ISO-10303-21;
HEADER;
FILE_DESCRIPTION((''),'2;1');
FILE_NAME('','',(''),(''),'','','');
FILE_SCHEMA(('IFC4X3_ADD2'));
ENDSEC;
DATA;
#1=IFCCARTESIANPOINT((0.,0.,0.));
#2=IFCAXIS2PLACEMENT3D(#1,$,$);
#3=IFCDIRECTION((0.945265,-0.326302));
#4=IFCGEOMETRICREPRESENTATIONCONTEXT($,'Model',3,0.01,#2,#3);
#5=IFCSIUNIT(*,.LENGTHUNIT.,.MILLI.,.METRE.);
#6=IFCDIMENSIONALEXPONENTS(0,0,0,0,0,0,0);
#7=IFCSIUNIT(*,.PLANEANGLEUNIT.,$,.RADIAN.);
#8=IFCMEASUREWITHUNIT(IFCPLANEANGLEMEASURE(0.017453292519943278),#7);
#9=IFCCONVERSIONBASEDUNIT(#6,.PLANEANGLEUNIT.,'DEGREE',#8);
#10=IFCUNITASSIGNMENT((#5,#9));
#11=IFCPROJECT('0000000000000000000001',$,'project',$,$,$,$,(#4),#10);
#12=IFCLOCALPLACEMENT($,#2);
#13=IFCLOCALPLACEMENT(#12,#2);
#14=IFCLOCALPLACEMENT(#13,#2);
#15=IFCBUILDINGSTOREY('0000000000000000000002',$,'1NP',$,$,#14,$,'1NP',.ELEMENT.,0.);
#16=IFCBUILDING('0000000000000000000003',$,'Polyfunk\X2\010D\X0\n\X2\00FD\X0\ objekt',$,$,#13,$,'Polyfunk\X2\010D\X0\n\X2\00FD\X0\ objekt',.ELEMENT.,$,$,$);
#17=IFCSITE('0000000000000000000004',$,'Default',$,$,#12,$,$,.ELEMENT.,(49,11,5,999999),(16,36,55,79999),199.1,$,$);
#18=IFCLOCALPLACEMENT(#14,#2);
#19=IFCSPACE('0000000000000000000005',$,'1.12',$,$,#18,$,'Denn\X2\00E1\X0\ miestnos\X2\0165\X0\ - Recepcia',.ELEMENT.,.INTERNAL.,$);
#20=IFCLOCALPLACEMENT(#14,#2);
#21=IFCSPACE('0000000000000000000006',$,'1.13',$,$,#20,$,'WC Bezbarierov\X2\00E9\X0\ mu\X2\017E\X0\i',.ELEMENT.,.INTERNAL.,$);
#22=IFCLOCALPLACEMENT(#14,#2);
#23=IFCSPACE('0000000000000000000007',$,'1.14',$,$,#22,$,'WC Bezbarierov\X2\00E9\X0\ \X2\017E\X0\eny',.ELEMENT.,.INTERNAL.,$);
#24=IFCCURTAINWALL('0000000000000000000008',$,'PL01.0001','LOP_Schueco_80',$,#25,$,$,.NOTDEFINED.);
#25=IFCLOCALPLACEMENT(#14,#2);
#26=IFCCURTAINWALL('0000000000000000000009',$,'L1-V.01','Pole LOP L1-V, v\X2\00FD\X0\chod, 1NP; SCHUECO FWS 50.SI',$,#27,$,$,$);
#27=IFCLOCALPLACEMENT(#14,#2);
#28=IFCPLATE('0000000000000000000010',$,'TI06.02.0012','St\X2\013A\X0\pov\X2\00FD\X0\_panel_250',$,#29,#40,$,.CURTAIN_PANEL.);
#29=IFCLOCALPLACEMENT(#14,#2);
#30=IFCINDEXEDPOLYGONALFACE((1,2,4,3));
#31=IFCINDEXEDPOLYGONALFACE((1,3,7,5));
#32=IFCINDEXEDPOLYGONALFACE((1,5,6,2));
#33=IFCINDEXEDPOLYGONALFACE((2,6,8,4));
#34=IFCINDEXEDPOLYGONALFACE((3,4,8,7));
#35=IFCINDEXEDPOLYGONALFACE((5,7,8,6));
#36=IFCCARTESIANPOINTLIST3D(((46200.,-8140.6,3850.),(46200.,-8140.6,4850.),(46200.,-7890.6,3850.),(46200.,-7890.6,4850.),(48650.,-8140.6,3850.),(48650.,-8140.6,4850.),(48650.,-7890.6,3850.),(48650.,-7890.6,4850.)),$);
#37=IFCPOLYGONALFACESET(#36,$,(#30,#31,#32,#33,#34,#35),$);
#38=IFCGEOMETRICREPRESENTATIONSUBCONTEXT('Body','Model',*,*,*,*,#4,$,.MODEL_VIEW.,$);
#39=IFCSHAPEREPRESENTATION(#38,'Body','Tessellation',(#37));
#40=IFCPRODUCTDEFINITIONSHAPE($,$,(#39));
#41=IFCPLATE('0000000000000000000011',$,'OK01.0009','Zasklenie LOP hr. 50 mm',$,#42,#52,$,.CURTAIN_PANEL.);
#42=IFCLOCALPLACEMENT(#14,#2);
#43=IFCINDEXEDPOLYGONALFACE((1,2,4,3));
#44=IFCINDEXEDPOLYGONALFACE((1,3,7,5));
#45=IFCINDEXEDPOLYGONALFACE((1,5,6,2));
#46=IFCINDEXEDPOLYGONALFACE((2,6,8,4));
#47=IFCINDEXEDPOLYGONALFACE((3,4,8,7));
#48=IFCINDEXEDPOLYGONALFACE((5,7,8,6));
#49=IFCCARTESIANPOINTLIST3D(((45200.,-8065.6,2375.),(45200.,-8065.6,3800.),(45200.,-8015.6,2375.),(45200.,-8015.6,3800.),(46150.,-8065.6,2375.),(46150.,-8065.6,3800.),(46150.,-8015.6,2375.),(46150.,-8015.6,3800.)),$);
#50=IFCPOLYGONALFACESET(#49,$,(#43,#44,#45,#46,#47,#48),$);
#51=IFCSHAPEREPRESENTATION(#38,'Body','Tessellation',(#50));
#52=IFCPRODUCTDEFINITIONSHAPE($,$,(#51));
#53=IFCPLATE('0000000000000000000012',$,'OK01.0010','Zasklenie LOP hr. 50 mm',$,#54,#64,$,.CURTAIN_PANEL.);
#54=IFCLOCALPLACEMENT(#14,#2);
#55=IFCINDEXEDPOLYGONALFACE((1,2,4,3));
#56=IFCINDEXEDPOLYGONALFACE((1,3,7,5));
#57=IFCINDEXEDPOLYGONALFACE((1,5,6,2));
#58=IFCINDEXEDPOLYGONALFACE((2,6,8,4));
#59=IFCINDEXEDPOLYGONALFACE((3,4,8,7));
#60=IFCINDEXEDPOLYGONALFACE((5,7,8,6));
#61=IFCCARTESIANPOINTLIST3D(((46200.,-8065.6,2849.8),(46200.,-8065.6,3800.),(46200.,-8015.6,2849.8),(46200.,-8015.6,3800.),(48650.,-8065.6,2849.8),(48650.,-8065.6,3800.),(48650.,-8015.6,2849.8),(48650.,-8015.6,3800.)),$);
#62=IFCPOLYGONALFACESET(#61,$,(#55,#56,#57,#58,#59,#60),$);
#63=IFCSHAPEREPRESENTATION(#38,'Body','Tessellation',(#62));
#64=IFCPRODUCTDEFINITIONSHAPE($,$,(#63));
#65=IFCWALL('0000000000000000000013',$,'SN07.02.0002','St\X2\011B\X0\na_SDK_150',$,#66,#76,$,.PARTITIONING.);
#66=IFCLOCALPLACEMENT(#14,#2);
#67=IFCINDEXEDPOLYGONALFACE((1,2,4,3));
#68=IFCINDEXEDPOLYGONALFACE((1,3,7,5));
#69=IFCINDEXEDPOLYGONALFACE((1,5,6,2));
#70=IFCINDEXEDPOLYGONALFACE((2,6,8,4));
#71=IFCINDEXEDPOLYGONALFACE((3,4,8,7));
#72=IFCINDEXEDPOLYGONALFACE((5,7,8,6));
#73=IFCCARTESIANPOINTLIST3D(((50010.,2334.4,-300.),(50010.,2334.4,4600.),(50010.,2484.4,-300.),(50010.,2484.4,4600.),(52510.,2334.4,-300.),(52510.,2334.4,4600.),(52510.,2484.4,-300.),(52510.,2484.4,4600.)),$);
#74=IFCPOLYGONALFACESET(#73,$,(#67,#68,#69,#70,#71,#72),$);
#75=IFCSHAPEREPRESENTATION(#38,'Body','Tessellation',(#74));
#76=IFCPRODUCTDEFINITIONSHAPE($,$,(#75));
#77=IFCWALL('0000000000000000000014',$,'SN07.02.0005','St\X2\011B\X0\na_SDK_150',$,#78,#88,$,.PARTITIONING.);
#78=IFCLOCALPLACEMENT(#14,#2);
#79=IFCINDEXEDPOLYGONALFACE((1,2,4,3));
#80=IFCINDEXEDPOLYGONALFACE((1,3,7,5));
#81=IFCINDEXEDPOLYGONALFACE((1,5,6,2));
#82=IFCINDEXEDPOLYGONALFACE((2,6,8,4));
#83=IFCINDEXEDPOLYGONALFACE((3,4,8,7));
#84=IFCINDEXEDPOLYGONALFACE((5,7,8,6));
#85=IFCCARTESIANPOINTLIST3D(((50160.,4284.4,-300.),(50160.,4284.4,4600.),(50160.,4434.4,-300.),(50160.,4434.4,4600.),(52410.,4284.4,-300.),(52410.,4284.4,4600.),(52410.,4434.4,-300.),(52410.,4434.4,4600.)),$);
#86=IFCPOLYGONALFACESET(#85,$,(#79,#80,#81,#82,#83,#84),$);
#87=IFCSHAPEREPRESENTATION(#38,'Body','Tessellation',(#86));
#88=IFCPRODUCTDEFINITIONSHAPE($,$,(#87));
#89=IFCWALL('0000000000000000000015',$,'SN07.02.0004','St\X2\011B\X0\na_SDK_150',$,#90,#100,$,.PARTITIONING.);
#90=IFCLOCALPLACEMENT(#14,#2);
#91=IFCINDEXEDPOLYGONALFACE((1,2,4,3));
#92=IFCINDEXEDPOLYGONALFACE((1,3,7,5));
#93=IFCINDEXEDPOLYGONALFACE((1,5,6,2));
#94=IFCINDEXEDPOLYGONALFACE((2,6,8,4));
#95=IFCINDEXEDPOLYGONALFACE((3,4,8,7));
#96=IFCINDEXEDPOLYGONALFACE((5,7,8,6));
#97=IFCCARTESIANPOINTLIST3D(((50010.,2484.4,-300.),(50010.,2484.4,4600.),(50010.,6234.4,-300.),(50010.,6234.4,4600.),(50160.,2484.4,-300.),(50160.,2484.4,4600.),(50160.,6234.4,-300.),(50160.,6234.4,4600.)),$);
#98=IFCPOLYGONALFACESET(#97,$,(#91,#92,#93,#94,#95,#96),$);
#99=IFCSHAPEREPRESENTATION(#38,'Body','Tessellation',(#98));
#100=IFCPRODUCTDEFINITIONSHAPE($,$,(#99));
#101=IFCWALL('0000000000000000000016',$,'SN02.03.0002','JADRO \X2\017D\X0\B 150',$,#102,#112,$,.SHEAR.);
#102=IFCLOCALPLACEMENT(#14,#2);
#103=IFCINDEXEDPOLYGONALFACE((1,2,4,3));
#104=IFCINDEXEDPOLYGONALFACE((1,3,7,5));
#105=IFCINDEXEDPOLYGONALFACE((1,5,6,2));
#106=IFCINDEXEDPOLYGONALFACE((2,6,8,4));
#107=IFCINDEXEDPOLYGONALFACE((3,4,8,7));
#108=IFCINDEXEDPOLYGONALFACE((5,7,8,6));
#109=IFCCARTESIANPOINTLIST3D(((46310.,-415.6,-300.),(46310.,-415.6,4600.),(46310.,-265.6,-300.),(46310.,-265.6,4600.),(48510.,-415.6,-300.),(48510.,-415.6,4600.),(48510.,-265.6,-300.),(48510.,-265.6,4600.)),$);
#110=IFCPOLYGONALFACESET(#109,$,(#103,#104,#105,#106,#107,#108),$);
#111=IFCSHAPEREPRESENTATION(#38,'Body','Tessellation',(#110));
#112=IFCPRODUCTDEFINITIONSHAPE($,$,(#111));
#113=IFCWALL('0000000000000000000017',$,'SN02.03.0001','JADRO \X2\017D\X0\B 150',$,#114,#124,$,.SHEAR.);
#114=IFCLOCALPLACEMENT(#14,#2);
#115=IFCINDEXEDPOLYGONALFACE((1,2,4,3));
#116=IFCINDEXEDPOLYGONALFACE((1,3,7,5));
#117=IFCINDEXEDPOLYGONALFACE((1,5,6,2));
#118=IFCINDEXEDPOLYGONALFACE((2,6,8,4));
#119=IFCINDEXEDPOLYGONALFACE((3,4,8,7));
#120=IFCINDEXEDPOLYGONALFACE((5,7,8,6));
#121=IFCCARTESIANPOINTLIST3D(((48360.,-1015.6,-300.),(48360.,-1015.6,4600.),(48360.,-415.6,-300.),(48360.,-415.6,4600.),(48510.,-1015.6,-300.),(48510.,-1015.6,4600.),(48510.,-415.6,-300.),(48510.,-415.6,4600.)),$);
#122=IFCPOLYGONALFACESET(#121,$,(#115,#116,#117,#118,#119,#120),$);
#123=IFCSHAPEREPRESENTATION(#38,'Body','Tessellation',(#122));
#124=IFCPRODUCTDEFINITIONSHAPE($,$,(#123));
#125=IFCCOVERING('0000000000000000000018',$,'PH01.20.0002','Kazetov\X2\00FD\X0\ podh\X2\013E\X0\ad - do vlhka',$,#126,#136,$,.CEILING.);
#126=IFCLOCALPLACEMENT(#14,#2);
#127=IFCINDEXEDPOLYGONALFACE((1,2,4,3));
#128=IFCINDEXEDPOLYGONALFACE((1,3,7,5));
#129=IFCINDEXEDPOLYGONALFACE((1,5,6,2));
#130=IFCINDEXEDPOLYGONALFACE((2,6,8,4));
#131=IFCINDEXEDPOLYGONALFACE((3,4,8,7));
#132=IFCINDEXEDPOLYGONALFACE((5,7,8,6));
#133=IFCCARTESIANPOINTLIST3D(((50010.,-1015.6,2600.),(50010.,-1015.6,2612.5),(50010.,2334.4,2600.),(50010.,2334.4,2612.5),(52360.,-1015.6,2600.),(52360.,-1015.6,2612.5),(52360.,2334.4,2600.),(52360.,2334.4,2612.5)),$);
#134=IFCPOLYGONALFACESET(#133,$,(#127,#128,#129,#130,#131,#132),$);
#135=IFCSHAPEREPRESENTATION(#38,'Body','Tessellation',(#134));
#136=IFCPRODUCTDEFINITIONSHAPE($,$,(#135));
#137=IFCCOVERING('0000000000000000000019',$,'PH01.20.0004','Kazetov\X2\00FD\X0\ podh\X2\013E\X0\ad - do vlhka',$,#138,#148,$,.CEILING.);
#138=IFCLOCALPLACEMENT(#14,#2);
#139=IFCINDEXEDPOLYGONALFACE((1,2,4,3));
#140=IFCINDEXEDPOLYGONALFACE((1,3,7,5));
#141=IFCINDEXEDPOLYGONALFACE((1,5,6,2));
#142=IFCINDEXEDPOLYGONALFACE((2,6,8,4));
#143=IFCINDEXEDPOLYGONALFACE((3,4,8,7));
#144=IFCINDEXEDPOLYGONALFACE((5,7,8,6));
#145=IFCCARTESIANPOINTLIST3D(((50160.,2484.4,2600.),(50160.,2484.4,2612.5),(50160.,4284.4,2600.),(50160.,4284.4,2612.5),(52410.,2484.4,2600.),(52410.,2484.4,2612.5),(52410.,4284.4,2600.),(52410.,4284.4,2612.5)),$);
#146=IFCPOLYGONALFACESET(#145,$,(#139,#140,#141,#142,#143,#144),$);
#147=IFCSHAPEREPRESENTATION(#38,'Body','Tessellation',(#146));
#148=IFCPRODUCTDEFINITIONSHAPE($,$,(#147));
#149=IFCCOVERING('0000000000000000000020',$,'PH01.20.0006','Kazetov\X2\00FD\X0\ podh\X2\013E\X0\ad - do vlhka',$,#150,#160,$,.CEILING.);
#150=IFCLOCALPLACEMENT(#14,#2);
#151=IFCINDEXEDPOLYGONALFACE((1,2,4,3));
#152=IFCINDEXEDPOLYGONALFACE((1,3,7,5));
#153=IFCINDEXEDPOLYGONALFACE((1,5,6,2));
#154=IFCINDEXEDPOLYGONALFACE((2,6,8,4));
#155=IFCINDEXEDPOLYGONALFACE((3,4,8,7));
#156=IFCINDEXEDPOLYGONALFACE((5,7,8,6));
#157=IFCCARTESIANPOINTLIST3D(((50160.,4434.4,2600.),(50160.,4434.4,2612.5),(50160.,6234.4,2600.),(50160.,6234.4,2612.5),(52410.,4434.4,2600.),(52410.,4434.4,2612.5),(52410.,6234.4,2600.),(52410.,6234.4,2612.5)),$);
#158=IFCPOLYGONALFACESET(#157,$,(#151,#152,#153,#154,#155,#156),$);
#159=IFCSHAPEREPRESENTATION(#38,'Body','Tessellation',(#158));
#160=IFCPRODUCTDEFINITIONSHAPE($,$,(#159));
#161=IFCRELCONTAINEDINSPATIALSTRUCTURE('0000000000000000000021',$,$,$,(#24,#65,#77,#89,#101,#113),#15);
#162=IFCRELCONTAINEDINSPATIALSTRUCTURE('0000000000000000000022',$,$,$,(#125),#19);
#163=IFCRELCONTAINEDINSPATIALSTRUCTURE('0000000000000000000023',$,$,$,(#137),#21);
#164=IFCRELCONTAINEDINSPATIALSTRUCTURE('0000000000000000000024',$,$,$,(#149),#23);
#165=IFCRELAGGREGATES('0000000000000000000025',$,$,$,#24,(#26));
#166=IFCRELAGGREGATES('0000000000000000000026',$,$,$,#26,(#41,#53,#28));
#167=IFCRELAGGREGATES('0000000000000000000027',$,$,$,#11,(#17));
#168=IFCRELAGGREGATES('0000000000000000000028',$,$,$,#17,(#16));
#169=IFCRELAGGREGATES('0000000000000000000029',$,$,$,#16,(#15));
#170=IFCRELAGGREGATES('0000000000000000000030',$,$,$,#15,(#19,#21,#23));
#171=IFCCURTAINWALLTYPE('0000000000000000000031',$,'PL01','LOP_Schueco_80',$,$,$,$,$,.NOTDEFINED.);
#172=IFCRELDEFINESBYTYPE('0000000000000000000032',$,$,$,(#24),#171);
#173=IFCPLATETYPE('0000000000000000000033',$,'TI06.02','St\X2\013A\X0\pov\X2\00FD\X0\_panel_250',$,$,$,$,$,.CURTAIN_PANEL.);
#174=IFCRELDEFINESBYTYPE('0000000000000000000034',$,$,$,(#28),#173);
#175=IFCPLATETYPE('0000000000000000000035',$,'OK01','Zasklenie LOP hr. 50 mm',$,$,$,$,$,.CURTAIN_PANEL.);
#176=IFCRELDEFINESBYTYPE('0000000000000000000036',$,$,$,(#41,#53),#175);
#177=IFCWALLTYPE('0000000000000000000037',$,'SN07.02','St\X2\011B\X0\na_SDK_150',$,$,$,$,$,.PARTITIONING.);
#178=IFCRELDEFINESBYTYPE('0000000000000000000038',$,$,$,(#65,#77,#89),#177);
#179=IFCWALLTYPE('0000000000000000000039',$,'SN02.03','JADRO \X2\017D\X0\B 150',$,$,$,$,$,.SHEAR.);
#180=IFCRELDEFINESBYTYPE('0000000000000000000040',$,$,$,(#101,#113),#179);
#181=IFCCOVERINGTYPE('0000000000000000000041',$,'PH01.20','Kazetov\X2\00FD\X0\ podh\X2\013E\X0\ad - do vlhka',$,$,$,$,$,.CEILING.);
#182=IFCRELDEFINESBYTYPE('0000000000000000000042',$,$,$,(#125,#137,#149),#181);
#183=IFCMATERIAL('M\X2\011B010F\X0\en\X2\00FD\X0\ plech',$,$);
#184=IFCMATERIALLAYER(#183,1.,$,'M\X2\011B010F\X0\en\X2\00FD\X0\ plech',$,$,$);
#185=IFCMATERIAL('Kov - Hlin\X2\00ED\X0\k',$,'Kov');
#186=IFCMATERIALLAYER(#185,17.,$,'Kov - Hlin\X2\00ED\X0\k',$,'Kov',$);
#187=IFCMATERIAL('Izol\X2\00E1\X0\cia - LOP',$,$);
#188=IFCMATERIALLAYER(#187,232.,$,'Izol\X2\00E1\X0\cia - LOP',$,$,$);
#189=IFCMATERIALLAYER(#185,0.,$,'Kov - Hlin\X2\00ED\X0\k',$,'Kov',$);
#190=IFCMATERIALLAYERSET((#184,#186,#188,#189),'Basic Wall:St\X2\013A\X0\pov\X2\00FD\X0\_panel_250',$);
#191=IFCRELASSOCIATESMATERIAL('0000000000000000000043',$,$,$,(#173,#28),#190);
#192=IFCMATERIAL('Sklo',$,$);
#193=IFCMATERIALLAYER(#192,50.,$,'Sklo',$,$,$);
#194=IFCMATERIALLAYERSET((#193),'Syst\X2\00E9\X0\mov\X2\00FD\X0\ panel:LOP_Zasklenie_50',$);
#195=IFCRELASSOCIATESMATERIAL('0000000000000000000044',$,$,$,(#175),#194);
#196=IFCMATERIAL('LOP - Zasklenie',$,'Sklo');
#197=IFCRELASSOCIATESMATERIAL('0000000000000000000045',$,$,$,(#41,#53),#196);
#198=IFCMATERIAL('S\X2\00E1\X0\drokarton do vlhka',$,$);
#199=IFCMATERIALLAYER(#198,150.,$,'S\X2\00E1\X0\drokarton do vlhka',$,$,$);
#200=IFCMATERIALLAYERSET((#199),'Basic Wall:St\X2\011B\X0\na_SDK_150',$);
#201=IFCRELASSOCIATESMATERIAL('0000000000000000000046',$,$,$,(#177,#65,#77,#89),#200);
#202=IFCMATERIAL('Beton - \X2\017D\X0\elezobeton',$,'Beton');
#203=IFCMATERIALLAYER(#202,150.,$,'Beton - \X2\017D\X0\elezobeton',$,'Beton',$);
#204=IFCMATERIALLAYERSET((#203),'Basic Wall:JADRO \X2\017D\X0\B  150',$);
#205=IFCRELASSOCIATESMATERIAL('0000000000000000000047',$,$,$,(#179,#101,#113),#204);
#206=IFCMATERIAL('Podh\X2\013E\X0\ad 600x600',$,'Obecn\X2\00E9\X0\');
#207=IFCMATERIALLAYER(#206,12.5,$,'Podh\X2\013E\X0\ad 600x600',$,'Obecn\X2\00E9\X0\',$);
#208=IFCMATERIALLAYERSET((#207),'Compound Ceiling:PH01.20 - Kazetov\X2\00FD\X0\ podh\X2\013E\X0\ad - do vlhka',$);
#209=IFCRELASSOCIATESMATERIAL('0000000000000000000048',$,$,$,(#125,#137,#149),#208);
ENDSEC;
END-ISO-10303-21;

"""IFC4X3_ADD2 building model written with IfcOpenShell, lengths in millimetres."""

from ifc_helpers import new_model, entity, si_unit, converted_unit, direction, frame, frame_2d, origin, origin_2d_with_axis, place, context, subcontext, project, spatial, polyline, rectangle, extrude, clip, bounded_halfspace, source, transform, mapped, material, layer, layer_set, layer_usage, type_object, type_shapes, element, aggregate, save


model = new_model("IFC4X3_ADD2")

# Units and contexts
model_context = context("Model", 3, precision=0.01, world=origin(), true_north=direction((0.945265, -0.326302)))
body_context = subcontext(model_context, "Body", "Model", "MODEL_VIEW")
ifc_project = project(units=[si_unit("LENGTHUNIT", "METRE", prefix="MILLI"), converted_unit("PLANEANGLEUNIT", "DEGREE", entity("IfcPlaneAngleMeasure", 0.017453292519943278), si_unit("PLANEANGLEUNIT", "RADIAN"), dimensions=[0, 0, 0, 0, 0, 0, 0])], contexts=[model_context])

# Site, building, storey
site_placement = place(None, origin())
site = spatial("IfcSite", under=ifc_project, at=site_placement, Name="Default", CompositionType="ELEMENT", RefLatitude=(49, 11, 5, 999999), RefLongitude=(16, 36, 55, 79999), RefElevation=199.1)
building_placement = place(site_placement, origin())
building = spatial("IfcBuilding", under=site, at=building_placement, Name="Polyfunkčný objekt", LongName="Polyfunkčný objekt", CompositionType="ELEMENT")
storey_placement = place(building_placement, origin())
storey = spatial("IfcBuildingStorey", under=building, at=storey_placement, Name="1NP", LongName="1NP", CompositionType="ELEMENT", Elevation=0.0)

# Curtain walls, plates
curtain_wall_type = type_object("IfcCurtainWallType", Name="PL01", Description="LOP_Schueco_80", PredefinedType="NOTDEFINED")
curtain_wall_1_placement = place(storey_placement, origin())
curtain_wall_1 = element("IfcCurtainWall", 1, at=curtain_wall_1_placement, inside=storey, type_object=curtain_wall_type, Name="PL01.0001", Description="LOP_Schueco_80", PredefinedType="NOTDEFINED")
curtain_wall_2 = element("IfcCurtainWall", 2, Name="L1-V.01", Description="Pole LOP L1-V, východ, 1NP; SCHUECO FWS 50.SI")
aggregate(curtain_wall_1, [curtain_wall_2])
ifc_material_1 = material(Name="Měďený plech")
ifc_layer_1 = layer(ifc_material_1, 1.0, Name="Měďený plech")
ifc_material_2 = material(Name="Kov - Hliník", Category="Kov")
ifc_layer_2 = layer(ifc_material_2, 17.0, Name="Kov - Hliník", Category="Kov")
ifc_material_3 = material(Name="Izolácia - LOP")
ifc_layer_3 = layer(ifc_material_3, 232.0, Name="Izolácia - LOP")
ifc_layer_4 = layer(ifc_material_2, 0.0, Name="Kov - Hliník", Category="Kov")
ifc_layer_set_1 = layer_set([ifc_layer_1, ifc_layer_2, ifc_layer_3, ifc_layer_4], Name="Basic Wall:Stĺpový_panel_250")
ifc_layer_usage_1 = layer_usage(ifc_layer_set_1, "AXIS2", "POSITIVE", -125.0)
plate_type_1 = type_object("IfcPlateType", Name="TI06.02", Description="Stĺpový_panel_250", PredefinedType="CURTAIN_PANEL", material=ifc_layer_set_1)
plate_1_placement = place(storey_placement, frame((46200.0, -8015.6, 3850.0)))
plate_1 = element("IfcPlate", 3, at=plate_1_placement, type_object=plate_type_1, material=ifc_layer_usage_1, Name="TI06.02.0012", Description="Stĺpový_panel_250", PredefinedType="CURTAIN_PANEL", context=body_context, shape_type="SweptSolid", body=[
    extrude(rectangle(XDim=250.0, YDim=2450.0, at=origin_2d_with_axis()), frame((1225.0, 0.0, 0.0), z_axis=(0.0, 0.0, 1.0), x_axis=(0.0, 1.0, 0.0)), (0.0, 0.0, 1.0), 1000.0),
])
ifc_material_4 = material(Name="LOP - Zasklenie", Category="Sklo")
ifc_material_5 = material(Name="Sklo")
ifc_layer_5 = layer(ifc_material_5, 50.0, Name="Sklo")
ifc_layer_set_2 = layer_set([ifc_layer_5], Name="Systémový panel:LOP_Zasklenie_50")
plate_type_2 = type_object("IfcPlateType", Name="OK01", Description="Zasklenie LOP hr. 50 mm", PredefinedType="CURTAIN_PANEL", material=ifc_layer_set_2)
shared_shape_1 = source(origin(), body_context, "Body", "SweptSolid", [
    extrude(rectangle(XDim=1425.0, YDim=950.0, at=frame_2d((87.6, 0.0), x_axis=(1.0, 0.0))), frame((0.0, -50.0, 624.9), z_axis=(0.0, 1.0, 0.0), x_axis=(0.0, 0.0, 1.0)), (0.0, 0.0, 1.0), 50.0),
])
plate_2_placement = place(curtain_wall_1_placement, frame((45675.0, -8015.6, 2375.0)))
plate_2 = element("IfcPlate", 4, at=plate_2_placement, type_object=plate_type_2, material=ifc_material_4, Name="OK01.0009", Description="Zasklenie LOP hr. 50 mm", PredefinedType="CURTAIN_PANEL", context=body_context, shape_type="MappedRepresentation", body=[
    mapped(shared_shape_1, transform((0.0, 0.0, 0.0), scale=1.0)),
])
shared_shape_2 = source(origin(), body_context, "Body", "SweptSolid", [
    extrude(rectangle(XDim=50.0, YDim=2450.0, at=origin_2d_with_axis()), frame((0.0, -25.0, 0.0), z_axis=(0.0, 0.0, 1.0), x_axis=(0.0, 1.0, 0.0)), (0.0, 0.0, 1.0), 950.2),
])
type_shapes(plate_type_2, [shared_shape_1, shared_shape_2])
plate_3_placement = place(curtain_wall_1_placement, frame((47425.0, -8015.6, 2849.8)))
plate_3 = element("IfcPlate", 5, at=plate_3_placement, type_object=plate_type_2, material=ifc_material_4, Name="OK01.0010", Description="Zasklenie LOP hr. 50 mm", PredefinedType="CURTAIN_PANEL", context=body_context, shape_type="MappedRepresentation", body=[
    mapped(shared_shape_2, transform((0.0, 0.0, 0.0), scale=1.0)),
])
aggregate(curtain_wall_2, [plate_2, plate_3, plate_1])

# Walls
ifc_material_6 = material(Name="Sádrokarton do vlhka")
ifc_layer_6 = layer(ifc_material_6, 150.0, Name="Sádrokarton do vlhka")
ifc_layer_set_3 = layer_set([ifc_layer_6], Name="Basic Wall:Stěna_SDK_150")
wall_type_1 = type_object("IfcWallType", Name="SN07.02", Description="Stěna_SDK_150", PredefinedType="PARTITIONING", material=ifc_layer_set_3)
wall_1_placement = place(storey_placement, frame((50010.0, 2409.4, -300.0)))
element("IfcWall", 6, at=wall_1_placement, inside=storey, type_object=wall_type_1, material=ifc_layer_set_3, Name="SN07.02.0002", Description="Stěna_SDK_150", PredefinedType="PARTITIONING", context=body_context, shape_type="Clipping", body=[
    clip(clip(extrude(rectangle(XDim=2500.0, YDim=150.0, at=frame_2d((1250.0, 0.0), x_axis=(-1.0, 0.0))), origin(), (0.0, 0.0, 1.0), 4900.0), bounded_halfspace(frame((2500.0, -75.0, 0.0), z_axis=(0.0, 0.0, 1.0), x_axis=(0.0, 1.0, 0.0)), True, frame((2500.0, -75.0, 0.0)), polyline([(0.0, 0.0), (0.0, 150.0), (-100.0, 150.0), (-2350.0, 150.0), (-2500.0, 150.0), (-2500.0, 0.0), (-150.0, 0.0), (0.0, 0.0)]))), bounded_halfspace(frame((0.0, -75.0, 4900.0), z_axis=(0.0, 0.0, -1.0), x_axis=(1.0, 0.0, 0.0)), True, frame((0.0, -75.0, 4900.0)), polyline([(0.0, 0.0), (2350.0, 0.0), (2500.0, 0.0), (2500.0, 150.0), (2400.0, 150.0), (150.0, 150.0), (0.0, 150.0), (0.0, 0.0)]))),
])
wall_2_placement = place(storey_placement, frame((50160.0, 4359.4, -300.0)))
element("IfcWall", 7, at=wall_2_placement, inside=storey, type_object=wall_type_1, material=ifc_layer_set_3, Name="SN07.02.0005", Description="Stěna_SDK_150", PredefinedType="PARTITIONING", context=body_context, shape_type="Clipping", body=[
    clip(clip(extrude(rectangle(XDim=2250.0, YDim=150.0, at=frame_2d((1125.0, 0.0), x_axis=(-1.0, 0.0))), origin(), (0.0, 0.0, 1.0), 4900.0), bounded_halfspace(frame((2250.0, -75.0, 0.0), z_axis=(0.0, 0.0, 1.0), x_axis=(0.0, 1.0, 0.0)), True, frame((2250.0, -75.0, 0.0)), polyline([(0.0, 0.0), (0.0, 150.0), (-2250.0, 150.0), (-2250.0, 0.0), (0.0, 0.0)]))), bounded_halfspace(frame((0.0, -75.0, 4900.0), z_axis=(0.0, 0.0, -1.0), x_axis=(1.0, 0.0, 0.0)), True, frame((0.0, -75.0, 4900.0)), polyline([(0.0, 0.0), (2250.0, 0.0), (2250.0, 150.0), (0.0, 150.0), (0.0, 0.0)]))),
])
wall_3_placement = place(storey_placement, frame((50085.0, 2484.4, -300.0), z_axis=(0.0, 0.0, 1.0), x_axis=(0.0, 1.0, 0.0)))
element("IfcWall", 8, at=wall_3_placement, inside=storey, type_object=wall_type_1, material=ifc_layer_set_3, Name="SN07.02.0004", Description="Stěna_SDK_150", PredefinedType="PARTITIONING", context=body_context, shape_type="Clipping", body=[
    clip(clip(extrude(rectangle(XDim=3750.0, YDim=150.0, at=frame_2d((1875.0, 0.0), x_axis=(-1.0, 0.0))), origin(), (0.0, 0.0, 1.0), 4900.0), bounded_halfspace(frame((0.0, -75.0, 4900.0), z_axis=(0.0, 0.0, -1.0), x_axis=(0.0, -1.0, 0.0)), True, frame((0.0, -75.0, 4900.0)), polyline([(0.0, 0.0), (1800.0, 0.0), (1950.0, 0.0), (3750.0, 0.0), (3750.0, 150.0), (0.0, 150.0), (0.0, 0.0)]))), bounded_halfspace(frame((3750.0, -75.0, 0.0)), True, frame((3750.0, -75.0, 0.0)), polyline([(0.0, 0.0), (0.0, 150.0), (-3750.0, 150.0), (-3750.0, 0.0), (-1950.0, 0.0), (-1800.0, 0.0), (0.0, 0.0)]))),
])
ifc_material_7 = material(Name="Beton - Železobeton", Category="Beton")
ifc_layer_7 = layer(ifc_material_7, 150.0, Name="Beton - Železobeton", Category="Beton")
ifc_layer_set_4 = layer_set([ifc_layer_7], Name="Basic Wall:JADRO ŽB  150")
wall_type_2 = type_object("IfcWallType", Name="SN02.03", Description="JADRO ŽB 150", PredefinedType="SHEAR", material=ifc_layer_set_4)
wall_4_placement = place(storey_placement, frame((46310.0, -340.6, -300.0)))
element("IfcWall", 9, at=wall_4_placement, inside=storey, type_object=wall_type_2, material=ifc_layer_set_4, Name="SN02.03.0002", Description="JADRO ŽB 150", PredefinedType="SHEAR", context=body_context, shape_type="SweptSolid", body=[
    extrude(rectangle(XDim=2200.0, YDim=150.0, at=frame_2d((1100.0, 0.0), x_axis=(-1.0, 0.0))), origin(), (0.0, 0.0, 1.0), 4900.0),
])
wall_5_placement = place(storey_placement, frame((48435.0, -1015.6, -300.0), z_axis=(0.0, 0.0, 1.0), x_axis=(0.0, 1.0, 0.0)))
element("IfcWall", 10, at=wall_5_placement, inside=storey, type_object=wall_type_2, material=ifc_layer_set_4, Name="SN02.03.0001", Description="JADRO ŽB 150", PredefinedType="SHEAR", context=body_context, shape_type="SweptSolid", body=[
    extrude(rectangle(XDim=600.0, YDim=150.0, at=frame_2d((300.0, 0.0), x_axis=(-1.0, 0.0))), origin(), (0.0, 0.0, 1.0), 4900.0),
])

# Shared definitions
space_1_placement = place(storey_placement, origin())
space_1 = spatial("IfcSpace", under=storey, at=space_1_placement, Name="1.12", LongName="Denná miestnosť - Recepcia", CompositionType="ELEMENT", PredefinedType="INTERNAL")

# Covering
ifc_material_8 = material(Name="Podhľad 600x600", Category="Obecné")
ifc_layer_8 = layer(ifc_material_8, 12.5, Name="Podhľad 600x600", Category="Obecné")
ifc_layer_set_5 = layer_set([ifc_layer_8], Name="Compound Ceiling:PH01.20 - Kazetový podhľad - do vlhka")
ifc_layer_usage_2 = layer_usage(ifc_layer_set_5, "AXIS3", "NEGATIVE", 12.5)
covering_type = type_object("IfcCoveringType", Name="PH01.20", Description="Kazetový podhľad - do vlhka", PredefinedType="CEILING")
covering_1_placement = place(storey_placement, frame((50010.0, -1015.6, 2600.0)))
element("IfcCovering", 11, at=covering_1_placement, inside=space_1, type_object=covering_type, material=ifc_layer_usage_2, Name="PH01.20.0002", Description="Kazetový podhľad - do vlhka", PredefinedType="CEILING", context=body_context, shape_type="SweptSolid", body=[
    extrude(rectangle(XDim=3350.0, YDim=2350.0, at=frame_2d((0.0, 0.0), x_axis=(1.0, 0.0))), frame((1175.0, 1675.0, 0.0), z_axis=(0.0, 0.0, 1.0), x_axis=(0.0, 1.0, 0.0)), (0.0, 0.0, 1.0), 12.5),
])

# Shared definitions
space_2_placement = place(storey_placement, origin())
space_2 = spatial("IfcSpace", under=storey, at=space_2_placement, Name="1.13", LongName="WC Bezbarierové muži", CompositionType="ELEMENT", PredefinedType="INTERNAL")

# Covering
ifc_layer_usage_3 = layer_usage(ifc_layer_set_5, "AXIS3", "NEGATIVE", 0.0)
covering_2_placement = place(storey_placement, frame((50160.0, 2484.4, 2600.0)))
element("IfcCovering", 12, at=covering_2_placement, inside=space_2, type_object=covering_type, material=ifc_layer_usage_3, Name="PH01.20.0004", Description="Kazetový podhľad - do vlhka", PredefinedType="CEILING", context=body_context, shape_type="SweptSolid", body=[
    extrude(rectangle(XDim=2250.0, YDim=1800.0, at=frame_2d((0.0, 0.0), x_axis=(1.0, 0.0))), frame((1125.0, 900.0, 0.0), z_axis=(0.0, 0.0, 1.0), x_axis=(-1.0, 0.0, 0.0)), (0.0, 0.0, 1.0), 12.5),
])

# Shared definitions
space_3_placement = place(storey_placement, origin())
space_3 = spatial("IfcSpace", under=storey, at=space_3_placement, Name="1.14", LongName="WC Bezbarierové ženy", CompositionType="ELEMENT", PredefinedType="INTERNAL")

# Covering
ifc_layer_usage_4 = layer_usage(ifc_layer_set_5, "AXIS3", "NEGATIVE", 0.0)
covering_3_placement = place(storey_placement, frame((50160.0, 4434.4, 2600.0)))
element("IfcCovering", 13, at=covering_3_placement, inside=space_3, type_object=covering_type, material=ifc_layer_usage_4, Name="PH01.20.0006", Description="Kazetový podhľad - do vlhka", PredefinedType="CEILING", context=body_context, shape_type="SweptSolid", body=[
    extrude(rectangle(XDim=1800.0, YDim=2250.0, at=frame_2d((0.0, 0.0), x_axis=(1.0, 0.0))), frame((1125.0, 900.0, 0.0), z_axis=(0.0, 0.0, 1.0), x_axis=(0.0, -1.0, 0.0)), (0.0, 0.0, 1.0), 12.5),
])

save(model, "model.ifc")
